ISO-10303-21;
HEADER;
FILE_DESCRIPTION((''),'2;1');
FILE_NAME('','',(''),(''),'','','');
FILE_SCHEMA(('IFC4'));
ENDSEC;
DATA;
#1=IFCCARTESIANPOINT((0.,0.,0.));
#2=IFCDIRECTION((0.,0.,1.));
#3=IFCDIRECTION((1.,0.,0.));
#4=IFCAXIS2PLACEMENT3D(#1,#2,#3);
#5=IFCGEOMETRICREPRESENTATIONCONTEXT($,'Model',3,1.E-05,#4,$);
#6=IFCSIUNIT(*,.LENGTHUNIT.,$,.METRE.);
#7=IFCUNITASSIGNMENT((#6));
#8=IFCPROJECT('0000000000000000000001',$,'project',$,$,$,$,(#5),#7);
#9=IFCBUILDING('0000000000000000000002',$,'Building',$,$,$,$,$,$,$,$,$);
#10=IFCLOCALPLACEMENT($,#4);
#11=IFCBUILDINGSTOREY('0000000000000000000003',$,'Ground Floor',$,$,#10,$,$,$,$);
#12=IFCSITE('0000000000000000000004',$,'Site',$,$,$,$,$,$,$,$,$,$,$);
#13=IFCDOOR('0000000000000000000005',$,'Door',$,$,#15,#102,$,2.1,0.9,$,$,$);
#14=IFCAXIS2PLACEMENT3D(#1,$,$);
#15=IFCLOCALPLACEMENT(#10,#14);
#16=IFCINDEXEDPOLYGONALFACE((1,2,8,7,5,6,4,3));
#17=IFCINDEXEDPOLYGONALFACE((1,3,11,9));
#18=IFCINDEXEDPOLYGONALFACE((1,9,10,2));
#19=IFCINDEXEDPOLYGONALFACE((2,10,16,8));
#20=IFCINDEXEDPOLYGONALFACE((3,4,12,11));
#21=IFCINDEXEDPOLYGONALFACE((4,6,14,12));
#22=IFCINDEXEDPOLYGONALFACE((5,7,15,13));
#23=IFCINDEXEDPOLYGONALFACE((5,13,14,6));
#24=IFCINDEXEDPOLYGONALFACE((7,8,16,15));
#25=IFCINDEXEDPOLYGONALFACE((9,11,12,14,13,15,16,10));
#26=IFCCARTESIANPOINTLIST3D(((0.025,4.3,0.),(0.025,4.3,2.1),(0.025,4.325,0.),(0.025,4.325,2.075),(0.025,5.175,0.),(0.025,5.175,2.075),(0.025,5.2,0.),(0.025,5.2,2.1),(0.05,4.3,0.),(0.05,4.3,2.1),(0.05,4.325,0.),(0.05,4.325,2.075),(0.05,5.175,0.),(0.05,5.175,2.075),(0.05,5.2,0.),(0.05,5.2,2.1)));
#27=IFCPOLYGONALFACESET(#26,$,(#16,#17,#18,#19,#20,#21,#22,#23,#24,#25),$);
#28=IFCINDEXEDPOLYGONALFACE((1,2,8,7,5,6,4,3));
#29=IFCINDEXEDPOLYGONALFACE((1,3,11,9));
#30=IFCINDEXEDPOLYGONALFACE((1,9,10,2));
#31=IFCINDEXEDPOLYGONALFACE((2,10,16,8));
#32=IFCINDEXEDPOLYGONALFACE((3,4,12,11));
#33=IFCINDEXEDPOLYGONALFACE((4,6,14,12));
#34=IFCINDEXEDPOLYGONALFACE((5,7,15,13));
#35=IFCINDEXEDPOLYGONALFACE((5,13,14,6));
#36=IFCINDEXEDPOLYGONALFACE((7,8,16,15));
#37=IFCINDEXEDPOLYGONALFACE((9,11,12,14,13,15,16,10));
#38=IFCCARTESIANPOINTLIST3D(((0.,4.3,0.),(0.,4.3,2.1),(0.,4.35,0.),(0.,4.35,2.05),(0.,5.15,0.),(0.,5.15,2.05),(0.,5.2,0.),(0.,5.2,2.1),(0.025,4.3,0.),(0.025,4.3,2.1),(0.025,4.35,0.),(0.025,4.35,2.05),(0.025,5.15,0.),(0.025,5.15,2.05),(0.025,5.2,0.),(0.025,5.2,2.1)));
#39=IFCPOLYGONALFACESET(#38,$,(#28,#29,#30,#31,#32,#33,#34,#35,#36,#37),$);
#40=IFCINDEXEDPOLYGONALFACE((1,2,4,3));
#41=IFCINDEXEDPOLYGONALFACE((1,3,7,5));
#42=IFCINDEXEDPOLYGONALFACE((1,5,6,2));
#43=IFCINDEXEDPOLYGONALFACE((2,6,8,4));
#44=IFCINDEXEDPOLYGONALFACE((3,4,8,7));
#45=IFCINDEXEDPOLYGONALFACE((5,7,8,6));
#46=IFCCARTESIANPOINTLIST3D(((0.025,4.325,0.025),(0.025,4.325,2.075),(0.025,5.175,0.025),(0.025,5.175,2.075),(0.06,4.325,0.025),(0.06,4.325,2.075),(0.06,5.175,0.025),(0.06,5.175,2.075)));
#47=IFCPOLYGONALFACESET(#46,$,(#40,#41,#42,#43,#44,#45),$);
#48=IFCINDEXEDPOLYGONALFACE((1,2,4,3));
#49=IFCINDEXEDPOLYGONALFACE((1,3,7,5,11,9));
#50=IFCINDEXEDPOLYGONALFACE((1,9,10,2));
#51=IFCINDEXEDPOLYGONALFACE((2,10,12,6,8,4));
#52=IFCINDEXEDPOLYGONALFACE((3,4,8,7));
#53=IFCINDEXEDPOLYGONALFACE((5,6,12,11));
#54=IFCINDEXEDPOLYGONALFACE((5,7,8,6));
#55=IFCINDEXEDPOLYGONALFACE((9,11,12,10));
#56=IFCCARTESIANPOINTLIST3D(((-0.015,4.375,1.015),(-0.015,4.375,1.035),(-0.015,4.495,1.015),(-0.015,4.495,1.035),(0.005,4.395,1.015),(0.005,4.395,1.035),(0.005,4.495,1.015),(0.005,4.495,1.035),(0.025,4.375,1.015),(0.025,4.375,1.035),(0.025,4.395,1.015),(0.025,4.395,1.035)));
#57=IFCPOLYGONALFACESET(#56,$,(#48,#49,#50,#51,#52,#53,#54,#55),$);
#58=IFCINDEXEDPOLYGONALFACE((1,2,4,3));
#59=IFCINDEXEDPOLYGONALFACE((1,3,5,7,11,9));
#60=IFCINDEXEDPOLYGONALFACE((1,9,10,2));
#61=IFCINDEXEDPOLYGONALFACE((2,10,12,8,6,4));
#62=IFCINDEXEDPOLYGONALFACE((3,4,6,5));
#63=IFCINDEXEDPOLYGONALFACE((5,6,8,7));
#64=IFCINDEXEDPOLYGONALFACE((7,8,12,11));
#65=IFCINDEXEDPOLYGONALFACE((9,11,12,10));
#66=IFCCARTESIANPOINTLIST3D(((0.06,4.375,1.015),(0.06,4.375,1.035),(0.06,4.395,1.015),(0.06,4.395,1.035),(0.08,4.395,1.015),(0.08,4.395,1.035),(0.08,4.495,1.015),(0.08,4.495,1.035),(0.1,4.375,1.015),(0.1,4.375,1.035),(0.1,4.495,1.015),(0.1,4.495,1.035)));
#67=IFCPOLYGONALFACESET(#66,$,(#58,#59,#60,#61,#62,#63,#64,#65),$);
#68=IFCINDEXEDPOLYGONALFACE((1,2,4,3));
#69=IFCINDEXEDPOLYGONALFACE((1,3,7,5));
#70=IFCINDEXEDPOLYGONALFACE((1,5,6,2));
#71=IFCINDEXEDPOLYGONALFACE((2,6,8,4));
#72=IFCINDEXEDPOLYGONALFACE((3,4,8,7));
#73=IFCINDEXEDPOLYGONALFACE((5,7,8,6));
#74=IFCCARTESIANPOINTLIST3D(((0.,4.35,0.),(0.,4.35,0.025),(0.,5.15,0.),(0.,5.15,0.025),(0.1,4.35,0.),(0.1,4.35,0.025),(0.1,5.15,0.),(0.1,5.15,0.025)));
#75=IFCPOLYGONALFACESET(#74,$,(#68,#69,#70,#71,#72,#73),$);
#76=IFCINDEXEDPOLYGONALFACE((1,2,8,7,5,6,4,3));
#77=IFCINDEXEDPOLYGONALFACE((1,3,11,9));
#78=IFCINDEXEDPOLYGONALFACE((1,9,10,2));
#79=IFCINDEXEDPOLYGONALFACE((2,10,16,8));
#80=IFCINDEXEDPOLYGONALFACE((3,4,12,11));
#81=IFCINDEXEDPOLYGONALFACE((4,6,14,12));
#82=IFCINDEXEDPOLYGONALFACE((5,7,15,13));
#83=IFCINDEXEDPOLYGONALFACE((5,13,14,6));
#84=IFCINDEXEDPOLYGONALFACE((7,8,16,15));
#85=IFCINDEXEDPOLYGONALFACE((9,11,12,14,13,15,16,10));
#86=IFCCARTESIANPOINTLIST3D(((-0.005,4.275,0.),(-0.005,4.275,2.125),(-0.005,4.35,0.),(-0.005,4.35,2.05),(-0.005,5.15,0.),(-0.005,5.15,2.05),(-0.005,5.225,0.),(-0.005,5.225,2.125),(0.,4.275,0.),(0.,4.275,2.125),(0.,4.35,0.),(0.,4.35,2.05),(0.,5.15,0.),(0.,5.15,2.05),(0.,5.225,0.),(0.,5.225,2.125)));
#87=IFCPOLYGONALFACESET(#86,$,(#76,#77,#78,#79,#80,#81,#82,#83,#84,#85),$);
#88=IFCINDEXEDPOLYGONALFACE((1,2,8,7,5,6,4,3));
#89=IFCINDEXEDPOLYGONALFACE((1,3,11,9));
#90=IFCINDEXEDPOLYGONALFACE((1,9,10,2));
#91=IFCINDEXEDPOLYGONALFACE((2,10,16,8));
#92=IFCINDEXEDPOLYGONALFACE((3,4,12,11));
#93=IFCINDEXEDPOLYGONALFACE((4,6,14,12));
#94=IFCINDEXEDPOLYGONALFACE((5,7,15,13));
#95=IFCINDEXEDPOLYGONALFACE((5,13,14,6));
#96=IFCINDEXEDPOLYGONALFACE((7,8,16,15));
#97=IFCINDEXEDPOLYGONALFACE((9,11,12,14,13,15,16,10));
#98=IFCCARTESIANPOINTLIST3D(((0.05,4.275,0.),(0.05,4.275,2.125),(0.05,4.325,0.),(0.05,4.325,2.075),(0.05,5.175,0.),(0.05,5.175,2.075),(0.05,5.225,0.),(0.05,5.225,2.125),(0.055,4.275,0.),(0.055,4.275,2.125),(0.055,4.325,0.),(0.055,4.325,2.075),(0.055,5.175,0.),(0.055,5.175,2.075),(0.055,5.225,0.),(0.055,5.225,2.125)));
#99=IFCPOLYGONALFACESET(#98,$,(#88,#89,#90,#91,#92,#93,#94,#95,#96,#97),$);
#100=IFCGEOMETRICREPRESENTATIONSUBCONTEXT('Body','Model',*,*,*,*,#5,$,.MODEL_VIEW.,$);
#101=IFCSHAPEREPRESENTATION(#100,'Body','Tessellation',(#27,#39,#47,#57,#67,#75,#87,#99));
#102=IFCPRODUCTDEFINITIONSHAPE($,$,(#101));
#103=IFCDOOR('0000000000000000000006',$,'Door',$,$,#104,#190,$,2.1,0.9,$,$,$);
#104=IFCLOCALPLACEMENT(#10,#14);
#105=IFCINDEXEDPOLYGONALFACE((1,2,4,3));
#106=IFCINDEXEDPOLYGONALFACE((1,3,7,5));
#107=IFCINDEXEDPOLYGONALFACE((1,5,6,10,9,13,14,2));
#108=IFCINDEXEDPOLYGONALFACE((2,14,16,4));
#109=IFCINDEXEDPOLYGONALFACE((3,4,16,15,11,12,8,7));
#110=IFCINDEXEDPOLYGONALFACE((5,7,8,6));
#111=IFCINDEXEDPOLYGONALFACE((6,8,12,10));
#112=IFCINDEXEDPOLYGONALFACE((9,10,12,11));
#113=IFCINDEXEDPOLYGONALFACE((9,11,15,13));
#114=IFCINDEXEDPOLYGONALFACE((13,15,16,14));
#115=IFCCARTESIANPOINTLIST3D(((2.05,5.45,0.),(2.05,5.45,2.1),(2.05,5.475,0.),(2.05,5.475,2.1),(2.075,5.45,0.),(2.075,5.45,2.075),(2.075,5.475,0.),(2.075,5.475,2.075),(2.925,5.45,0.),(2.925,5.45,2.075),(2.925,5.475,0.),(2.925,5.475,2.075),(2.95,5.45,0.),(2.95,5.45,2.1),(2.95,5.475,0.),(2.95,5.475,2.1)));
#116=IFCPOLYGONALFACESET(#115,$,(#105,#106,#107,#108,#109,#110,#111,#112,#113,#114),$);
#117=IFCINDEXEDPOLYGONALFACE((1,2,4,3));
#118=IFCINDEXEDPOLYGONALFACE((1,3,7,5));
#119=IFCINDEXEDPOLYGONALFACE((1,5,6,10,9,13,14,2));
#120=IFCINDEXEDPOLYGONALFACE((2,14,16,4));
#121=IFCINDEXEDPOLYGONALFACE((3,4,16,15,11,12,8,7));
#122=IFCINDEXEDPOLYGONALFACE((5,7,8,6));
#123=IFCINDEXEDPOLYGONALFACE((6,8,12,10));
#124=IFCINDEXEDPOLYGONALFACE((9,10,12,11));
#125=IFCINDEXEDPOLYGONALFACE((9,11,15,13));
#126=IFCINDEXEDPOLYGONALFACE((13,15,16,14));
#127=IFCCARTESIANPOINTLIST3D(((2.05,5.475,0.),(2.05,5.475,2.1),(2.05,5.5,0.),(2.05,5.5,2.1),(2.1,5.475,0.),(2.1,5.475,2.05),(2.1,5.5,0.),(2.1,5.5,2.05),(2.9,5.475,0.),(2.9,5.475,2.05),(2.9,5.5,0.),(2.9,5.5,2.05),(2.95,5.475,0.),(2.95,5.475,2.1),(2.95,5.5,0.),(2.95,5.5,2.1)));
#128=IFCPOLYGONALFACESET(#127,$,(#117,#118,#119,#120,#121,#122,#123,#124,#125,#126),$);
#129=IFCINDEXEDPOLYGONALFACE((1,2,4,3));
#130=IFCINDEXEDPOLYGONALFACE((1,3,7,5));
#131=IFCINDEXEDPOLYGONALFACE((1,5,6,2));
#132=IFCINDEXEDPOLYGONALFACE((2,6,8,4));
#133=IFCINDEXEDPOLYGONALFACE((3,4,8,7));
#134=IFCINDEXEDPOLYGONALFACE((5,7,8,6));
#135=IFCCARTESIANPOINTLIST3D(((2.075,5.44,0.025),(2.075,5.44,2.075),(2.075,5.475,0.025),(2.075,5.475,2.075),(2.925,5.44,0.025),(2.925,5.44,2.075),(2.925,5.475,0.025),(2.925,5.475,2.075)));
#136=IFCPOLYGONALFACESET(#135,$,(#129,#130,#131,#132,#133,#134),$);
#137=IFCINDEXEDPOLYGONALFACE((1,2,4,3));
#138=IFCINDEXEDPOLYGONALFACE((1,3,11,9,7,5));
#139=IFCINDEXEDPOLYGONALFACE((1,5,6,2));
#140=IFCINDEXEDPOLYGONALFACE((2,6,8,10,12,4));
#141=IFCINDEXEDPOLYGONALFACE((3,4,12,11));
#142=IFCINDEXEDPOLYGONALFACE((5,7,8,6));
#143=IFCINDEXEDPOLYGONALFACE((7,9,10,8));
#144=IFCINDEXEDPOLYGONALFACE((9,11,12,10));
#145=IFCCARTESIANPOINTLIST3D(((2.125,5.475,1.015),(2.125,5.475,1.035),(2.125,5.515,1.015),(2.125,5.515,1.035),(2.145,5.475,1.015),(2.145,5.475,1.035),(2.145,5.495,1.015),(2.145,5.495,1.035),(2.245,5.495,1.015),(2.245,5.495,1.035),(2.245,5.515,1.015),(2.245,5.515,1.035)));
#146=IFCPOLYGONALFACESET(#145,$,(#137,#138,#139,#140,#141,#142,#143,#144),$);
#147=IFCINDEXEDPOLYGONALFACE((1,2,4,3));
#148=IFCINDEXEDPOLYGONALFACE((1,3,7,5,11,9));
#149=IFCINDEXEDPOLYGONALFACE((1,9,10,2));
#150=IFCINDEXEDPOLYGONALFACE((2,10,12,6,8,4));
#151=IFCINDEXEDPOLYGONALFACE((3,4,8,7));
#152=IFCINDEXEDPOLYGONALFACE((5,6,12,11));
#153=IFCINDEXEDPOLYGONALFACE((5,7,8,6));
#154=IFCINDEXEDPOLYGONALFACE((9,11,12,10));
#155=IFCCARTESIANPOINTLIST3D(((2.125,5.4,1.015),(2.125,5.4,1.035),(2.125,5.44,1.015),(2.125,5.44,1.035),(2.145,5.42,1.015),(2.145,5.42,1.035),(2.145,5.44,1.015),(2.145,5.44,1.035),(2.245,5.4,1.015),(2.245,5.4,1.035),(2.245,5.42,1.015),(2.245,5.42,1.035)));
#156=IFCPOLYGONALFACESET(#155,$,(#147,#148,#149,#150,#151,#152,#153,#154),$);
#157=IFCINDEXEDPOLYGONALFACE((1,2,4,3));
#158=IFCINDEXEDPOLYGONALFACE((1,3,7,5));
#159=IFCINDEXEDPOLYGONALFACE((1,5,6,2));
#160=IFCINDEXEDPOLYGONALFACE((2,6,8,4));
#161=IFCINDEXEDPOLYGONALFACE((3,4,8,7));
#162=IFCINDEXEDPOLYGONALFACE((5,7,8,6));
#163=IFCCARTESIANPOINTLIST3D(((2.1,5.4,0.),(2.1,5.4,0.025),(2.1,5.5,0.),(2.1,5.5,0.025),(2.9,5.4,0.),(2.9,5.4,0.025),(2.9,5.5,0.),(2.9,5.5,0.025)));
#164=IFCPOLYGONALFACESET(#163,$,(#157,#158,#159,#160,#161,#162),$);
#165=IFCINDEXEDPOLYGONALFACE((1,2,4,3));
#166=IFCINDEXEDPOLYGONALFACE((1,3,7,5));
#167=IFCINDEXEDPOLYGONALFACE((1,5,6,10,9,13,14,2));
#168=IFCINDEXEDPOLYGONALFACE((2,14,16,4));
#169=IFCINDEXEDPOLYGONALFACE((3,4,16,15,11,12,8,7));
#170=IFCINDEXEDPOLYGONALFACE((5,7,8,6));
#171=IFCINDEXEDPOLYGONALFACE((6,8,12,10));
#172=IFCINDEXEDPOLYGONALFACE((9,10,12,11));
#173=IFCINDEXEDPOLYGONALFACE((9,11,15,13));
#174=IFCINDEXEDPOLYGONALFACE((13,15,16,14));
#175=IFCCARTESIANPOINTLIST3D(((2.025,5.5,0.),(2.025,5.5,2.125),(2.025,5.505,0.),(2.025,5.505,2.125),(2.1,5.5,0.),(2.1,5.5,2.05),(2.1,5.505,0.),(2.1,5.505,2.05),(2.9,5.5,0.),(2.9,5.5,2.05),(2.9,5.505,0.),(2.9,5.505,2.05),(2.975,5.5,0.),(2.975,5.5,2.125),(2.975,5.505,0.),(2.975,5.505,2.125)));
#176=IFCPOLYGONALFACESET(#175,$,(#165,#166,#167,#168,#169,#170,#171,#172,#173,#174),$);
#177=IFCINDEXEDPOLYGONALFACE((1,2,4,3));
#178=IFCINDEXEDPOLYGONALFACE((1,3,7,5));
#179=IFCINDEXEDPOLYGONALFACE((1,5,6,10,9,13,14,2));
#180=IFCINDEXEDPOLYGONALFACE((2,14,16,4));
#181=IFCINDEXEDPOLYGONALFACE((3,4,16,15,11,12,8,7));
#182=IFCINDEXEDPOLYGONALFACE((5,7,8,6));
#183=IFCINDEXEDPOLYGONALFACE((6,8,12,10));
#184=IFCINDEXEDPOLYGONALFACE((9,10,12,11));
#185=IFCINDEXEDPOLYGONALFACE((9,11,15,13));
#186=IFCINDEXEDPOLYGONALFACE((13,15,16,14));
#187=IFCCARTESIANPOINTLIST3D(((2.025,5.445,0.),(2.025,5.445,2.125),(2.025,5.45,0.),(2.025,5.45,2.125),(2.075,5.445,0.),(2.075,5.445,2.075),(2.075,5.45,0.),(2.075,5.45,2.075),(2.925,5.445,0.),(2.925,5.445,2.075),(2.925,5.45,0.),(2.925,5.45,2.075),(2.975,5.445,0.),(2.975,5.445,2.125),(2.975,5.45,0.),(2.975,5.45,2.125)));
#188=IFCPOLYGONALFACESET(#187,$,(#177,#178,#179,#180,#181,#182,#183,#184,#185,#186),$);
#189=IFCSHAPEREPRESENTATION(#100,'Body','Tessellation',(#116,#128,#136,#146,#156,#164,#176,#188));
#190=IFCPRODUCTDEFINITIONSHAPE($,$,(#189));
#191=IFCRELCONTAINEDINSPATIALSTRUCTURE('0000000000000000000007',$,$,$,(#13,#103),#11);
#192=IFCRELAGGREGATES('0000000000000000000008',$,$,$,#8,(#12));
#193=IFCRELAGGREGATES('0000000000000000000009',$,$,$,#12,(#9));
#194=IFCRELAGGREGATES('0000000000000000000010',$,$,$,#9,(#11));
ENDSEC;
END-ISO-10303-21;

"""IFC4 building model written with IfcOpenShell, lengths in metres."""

from ifc_helpers import new_model, si_unit, frame, origin_with_axes, place, context, subcontext, project, spatial, line, indexed_curve, outline, extrude, element, save


model = new_model("IFC4")

# Units and contexts
model_context = context("Model", 3, precision=1e-05, world=origin_with_axes())
body_context = subcontext(model_context, "Body", "Model", "MODEL_VIEW")
ifc_project = project(units=[si_unit("LENGTHUNIT", "METRE")], contexts=[model_context])

# Site, building, storey
site = spatial("IfcSite", under=ifc_project, Name="Site")
building = spatial("IfcBuilding", under=site, Name="Building")
storey_placement = place(None, origin_with_axes())
storey = spatial("IfcBuildingStorey", under=building, at=storey_placement, Name="Ground Floor")

# Doors
door_1_placement = place(storey_placement, frame((0.0, 5.2, 0.0), z_axis=(0.0, 0.0, 1.0), x_axis=(0.0, -1.0, 0.0)))
element("IfcDoor", 1, at=door_1_placement, inside=storey, Name="Door", OverallHeight=2.1, OverallWidth=0.9, context=body_context, shape_type="SweptSolid", body=[
    extrude(outline(indexed_curve([(0.0, 0.0), (0.0, 2.1), (0.9, 2.1), (0.9, 0.0), (0.875, 0.0), (0.875, 2.075), (0.025, 2.075), (0.025, 0.0)], segments=[line(1, 2, 3, 4, 5, 6, 7, 8, 1)])), frame((0.0, 0.025, 0.0), z_axis=(0.0, -1.0, 0.0), x_axis=(1.0, 0.0, 0.0)), (0.0, 0.0, -1.0), 0.025),
    extrude(outline(indexed_curve([(0.0, 0.0), (0.0, 2.1), (0.9, 2.1), (0.9, 0.0), (0.85, 0.0), (0.85, 2.05), (0.05, 2.05), (0.05, 0.0)], segments=[line(1, 2, 3, 4, 5, 6, 7, 8, 1)])), frame((0.0, 0.0, 0.0), z_axis=(0.0, -1.0, 0.0), x_axis=(1.0, 0.0, 0.0)), (0.0, 0.0, -1.0), 0.025),
    extrude(outline(indexed_curve([(0.0, 0.0), (0.85, 0.0), (0.85, 0.035), (0.0, 0.035)], segments=[line(1, 2, 3, 4, 1)])), frame((0.025, 0.025, 0.025), z_axis=(0.0, 0.0, 1.0), x_axis=(1.0, 0.0, 0.0)), (0.0, 0.0, 1.0), 2.05),
    extrude(outline(indexed_curve([(0.0, 0.0), (0.0, -0.04), (-0.12, -0.04), (-0.12, -0.02), (-0.02, -0.02), (-0.02, 0.0)], segments=[line(1, 2, 3, 4, 5, 6, 1)])), frame((0.825, 0.025, 1.015), z_axis=(0.0, 0.0, 1.0), x_axis=(1.0, 0.0, 0.0)), (0.0, 0.0, 1.0), 0.02),
    extrude(outline(indexed_curve([(0.0, 0.0), (0.0, 0.04), (-0.12, 0.04), (-0.12, 0.02), (-0.02, 0.02), (-0.02, 0.0)], segments=[line(1, 2, 3, 4, 5, 6, 1)])), frame((0.825, 0.06, 1.015), z_axis=(0.0, 0.0, 1.0), x_axis=(1.0, 0.0, 0.0)), (0.0, 0.0, 1.0), 0.02),
    extrude(outline(indexed_curve([(0.0, 0.0), (0.8, 0.0), (0.8, 0.1), (0.0, 0.1)], segments=[line(1, 2, 3, 4, 1)])), frame((0.05, 0.0, 0.0), z_axis=(0.0, 0.0, 1.0), x_axis=(1.0, 0.0, 0.0)), (0.0, 0.0, 1.0), 0.025),
    extrude(outline(indexed_curve([(0.0, 0.0), (0.0, 2.125), (0.95, 2.125), (0.95, 0.0), (0.875, 0.0), (0.875, 2.05), (0.075, 2.05), (0.075, 0.0)], segments=[line(1, 2, 3, 4, 5, 6, 7, 8, 1)])), frame((-0.025, -0.005, 0.0), z_axis=(0.0, -1.0, 0.0), x_axis=(1.0, 0.0, 0.0)), (0.0, 0.0, -1.0), 0.005),
    extrude(outline(indexed_curve([(0.0, 0.0), (0.0, 2.125), (0.95, 2.125), (0.95, 0.0), (0.9, 0.0), (0.9, 2.075), (0.05, 2.075), (0.05, 0.0)], segments=[line(1, 2, 3, 4, 5, 6, 7, 8, 1)])), frame((-0.025, 0.05, 0.0), z_axis=(0.0, -1.0, 0.0), x_axis=(1.0, 0.0, 0.0)), (0.0, 0.0, -1.0), 0.005),
])
door_2_placement = place(storey_placement, frame((2.95, 5.5, 0.0), z_axis=(0.0, 0.0, 1.0), x_axis=(-1.0, 0.0, 0.0)))
element("IfcDoor", 2, at=door_2_placement, inside=storey, Name="Door", OverallHeight=2.1, OverallWidth=0.9, context=body_context, shape_type="SweptSolid", body=[
    extrude(outline(indexed_curve([(0.0, 0.0), (0.0, 2.1), (0.9, 2.1), (0.9, 0.0), (0.875, 0.0), (0.875, 2.075), (0.025, 2.075), (0.025, 0.0)], segments=[line(1, 2, 3, 4, 5, 6, 7, 8, 1)])), frame((0.0, 0.025, 0.0), z_axis=(0.0, -1.0, 0.0), x_axis=(1.0, 0.0, 0.0)), (0.0, 0.0, -1.0), 0.025),
    extrude(outline(indexed_curve([(0.0, 0.0), (0.0, 2.1), (0.9, 2.1), (0.9, 0.0), (0.85, 0.0), (0.85, 2.05), (0.05, 2.05), (0.05, 0.0)], segments=[line(1, 2, 3, 4, 5, 6, 7, 8, 1)])), frame((0.0, 0.0, 0.0), z_axis=(0.0, -1.0, 0.0), x_axis=(1.0, 0.0, 0.0)), (0.0, 0.0, -1.0), 0.025),
    extrude(outline(indexed_curve([(0.0, 0.0), (0.85, 0.0), (0.85, 0.035), (0.0, 0.035)], segments=[line(1, 2, 3, 4, 1)])), frame((0.025, 0.025, 0.025), z_axis=(0.0, 0.0, 1.0), x_axis=(1.0, 0.0, 0.0)), (0.0, 0.0, 1.0), 2.05),
    extrude(outline(indexed_curve([(0.0, 0.0), (0.0, -0.04), (-0.12, -0.04), (-0.12, -0.02), (-0.02, -0.02), (-0.02, 0.0)], segments=[line(1, 2, 3, 4, 5, 6, 1)])), frame((0.825, 0.025, 1.015), z_axis=(0.0, 0.0, 1.0), x_axis=(1.0, 0.0, 0.0)), (0.0, 0.0, 1.0), 0.02),
    extrude(outline(indexed_curve([(0.0, 0.0), (0.0, 0.04), (-0.12, 0.04), (-0.12, 0.02), (-0.02, 0.02), (-0.02, 0.0)], segments=[line(1, 2, 3, 4, 5, 6, 1)])), frame((0.825, 0.06, 1.015), z_axis=(0.0, 0.0, 1.0), x_axis=(1.0, 0.0, 0.0)), (0.0, 0.0, 1.0), 0.02),
    extrude(outline(indexed_curve([(0.0, 0.0), (0.8, 0.0), (0.8, 0.1), (0.0, 0.1)], segments=[line(1, 2, 3, 4, 1)])), frame((0.05, 0.0, 0.0), z_axis=(0.0, 0.0, 1.0), x_axis=(1.0, 0.0, 0.0)), (0.0, 0.0, 1.0), 0.025),
    extrude(outline(indexed_curve([(0.0, 0.0), (0.0, 2.125), (0.95, 2.125), (0.95, 0.0), (0.875, 0.0), (0.875, 2.05), (0.075, 2.05), (0.075, 0.0)], segments=[line(1, 2, 3, 4, 5, 6, 7, 8, 1)])), frame((-0.025, -0.005, 0.0), z_axis=(0.0, -1.0, 0.0), x_axis=(1.0, 0.0, 0.0)), (0.0, 0.0, -1.0), 0.005),
    extrude(outline(indexed_curve([(0.0, 0.0), (0.0, 2.125), (0.95, 2.125), (0.95, 0.0), (0.9, 0.0), (0.9, 2.075), (0.05, 2.075), (0.05, 0.0)], segments=[line(1, 2, 3, 4, 5, 6, 7, 8, 1)])), frame((-0.025, 0.05, 0.0), z_axis=(0.0, -1.0, 0.0), x_axis=(1.0, 0.0, 0.0)), (0.0, 0.0, -1.0), 0.005),
])

save(model, "model.ifc")
